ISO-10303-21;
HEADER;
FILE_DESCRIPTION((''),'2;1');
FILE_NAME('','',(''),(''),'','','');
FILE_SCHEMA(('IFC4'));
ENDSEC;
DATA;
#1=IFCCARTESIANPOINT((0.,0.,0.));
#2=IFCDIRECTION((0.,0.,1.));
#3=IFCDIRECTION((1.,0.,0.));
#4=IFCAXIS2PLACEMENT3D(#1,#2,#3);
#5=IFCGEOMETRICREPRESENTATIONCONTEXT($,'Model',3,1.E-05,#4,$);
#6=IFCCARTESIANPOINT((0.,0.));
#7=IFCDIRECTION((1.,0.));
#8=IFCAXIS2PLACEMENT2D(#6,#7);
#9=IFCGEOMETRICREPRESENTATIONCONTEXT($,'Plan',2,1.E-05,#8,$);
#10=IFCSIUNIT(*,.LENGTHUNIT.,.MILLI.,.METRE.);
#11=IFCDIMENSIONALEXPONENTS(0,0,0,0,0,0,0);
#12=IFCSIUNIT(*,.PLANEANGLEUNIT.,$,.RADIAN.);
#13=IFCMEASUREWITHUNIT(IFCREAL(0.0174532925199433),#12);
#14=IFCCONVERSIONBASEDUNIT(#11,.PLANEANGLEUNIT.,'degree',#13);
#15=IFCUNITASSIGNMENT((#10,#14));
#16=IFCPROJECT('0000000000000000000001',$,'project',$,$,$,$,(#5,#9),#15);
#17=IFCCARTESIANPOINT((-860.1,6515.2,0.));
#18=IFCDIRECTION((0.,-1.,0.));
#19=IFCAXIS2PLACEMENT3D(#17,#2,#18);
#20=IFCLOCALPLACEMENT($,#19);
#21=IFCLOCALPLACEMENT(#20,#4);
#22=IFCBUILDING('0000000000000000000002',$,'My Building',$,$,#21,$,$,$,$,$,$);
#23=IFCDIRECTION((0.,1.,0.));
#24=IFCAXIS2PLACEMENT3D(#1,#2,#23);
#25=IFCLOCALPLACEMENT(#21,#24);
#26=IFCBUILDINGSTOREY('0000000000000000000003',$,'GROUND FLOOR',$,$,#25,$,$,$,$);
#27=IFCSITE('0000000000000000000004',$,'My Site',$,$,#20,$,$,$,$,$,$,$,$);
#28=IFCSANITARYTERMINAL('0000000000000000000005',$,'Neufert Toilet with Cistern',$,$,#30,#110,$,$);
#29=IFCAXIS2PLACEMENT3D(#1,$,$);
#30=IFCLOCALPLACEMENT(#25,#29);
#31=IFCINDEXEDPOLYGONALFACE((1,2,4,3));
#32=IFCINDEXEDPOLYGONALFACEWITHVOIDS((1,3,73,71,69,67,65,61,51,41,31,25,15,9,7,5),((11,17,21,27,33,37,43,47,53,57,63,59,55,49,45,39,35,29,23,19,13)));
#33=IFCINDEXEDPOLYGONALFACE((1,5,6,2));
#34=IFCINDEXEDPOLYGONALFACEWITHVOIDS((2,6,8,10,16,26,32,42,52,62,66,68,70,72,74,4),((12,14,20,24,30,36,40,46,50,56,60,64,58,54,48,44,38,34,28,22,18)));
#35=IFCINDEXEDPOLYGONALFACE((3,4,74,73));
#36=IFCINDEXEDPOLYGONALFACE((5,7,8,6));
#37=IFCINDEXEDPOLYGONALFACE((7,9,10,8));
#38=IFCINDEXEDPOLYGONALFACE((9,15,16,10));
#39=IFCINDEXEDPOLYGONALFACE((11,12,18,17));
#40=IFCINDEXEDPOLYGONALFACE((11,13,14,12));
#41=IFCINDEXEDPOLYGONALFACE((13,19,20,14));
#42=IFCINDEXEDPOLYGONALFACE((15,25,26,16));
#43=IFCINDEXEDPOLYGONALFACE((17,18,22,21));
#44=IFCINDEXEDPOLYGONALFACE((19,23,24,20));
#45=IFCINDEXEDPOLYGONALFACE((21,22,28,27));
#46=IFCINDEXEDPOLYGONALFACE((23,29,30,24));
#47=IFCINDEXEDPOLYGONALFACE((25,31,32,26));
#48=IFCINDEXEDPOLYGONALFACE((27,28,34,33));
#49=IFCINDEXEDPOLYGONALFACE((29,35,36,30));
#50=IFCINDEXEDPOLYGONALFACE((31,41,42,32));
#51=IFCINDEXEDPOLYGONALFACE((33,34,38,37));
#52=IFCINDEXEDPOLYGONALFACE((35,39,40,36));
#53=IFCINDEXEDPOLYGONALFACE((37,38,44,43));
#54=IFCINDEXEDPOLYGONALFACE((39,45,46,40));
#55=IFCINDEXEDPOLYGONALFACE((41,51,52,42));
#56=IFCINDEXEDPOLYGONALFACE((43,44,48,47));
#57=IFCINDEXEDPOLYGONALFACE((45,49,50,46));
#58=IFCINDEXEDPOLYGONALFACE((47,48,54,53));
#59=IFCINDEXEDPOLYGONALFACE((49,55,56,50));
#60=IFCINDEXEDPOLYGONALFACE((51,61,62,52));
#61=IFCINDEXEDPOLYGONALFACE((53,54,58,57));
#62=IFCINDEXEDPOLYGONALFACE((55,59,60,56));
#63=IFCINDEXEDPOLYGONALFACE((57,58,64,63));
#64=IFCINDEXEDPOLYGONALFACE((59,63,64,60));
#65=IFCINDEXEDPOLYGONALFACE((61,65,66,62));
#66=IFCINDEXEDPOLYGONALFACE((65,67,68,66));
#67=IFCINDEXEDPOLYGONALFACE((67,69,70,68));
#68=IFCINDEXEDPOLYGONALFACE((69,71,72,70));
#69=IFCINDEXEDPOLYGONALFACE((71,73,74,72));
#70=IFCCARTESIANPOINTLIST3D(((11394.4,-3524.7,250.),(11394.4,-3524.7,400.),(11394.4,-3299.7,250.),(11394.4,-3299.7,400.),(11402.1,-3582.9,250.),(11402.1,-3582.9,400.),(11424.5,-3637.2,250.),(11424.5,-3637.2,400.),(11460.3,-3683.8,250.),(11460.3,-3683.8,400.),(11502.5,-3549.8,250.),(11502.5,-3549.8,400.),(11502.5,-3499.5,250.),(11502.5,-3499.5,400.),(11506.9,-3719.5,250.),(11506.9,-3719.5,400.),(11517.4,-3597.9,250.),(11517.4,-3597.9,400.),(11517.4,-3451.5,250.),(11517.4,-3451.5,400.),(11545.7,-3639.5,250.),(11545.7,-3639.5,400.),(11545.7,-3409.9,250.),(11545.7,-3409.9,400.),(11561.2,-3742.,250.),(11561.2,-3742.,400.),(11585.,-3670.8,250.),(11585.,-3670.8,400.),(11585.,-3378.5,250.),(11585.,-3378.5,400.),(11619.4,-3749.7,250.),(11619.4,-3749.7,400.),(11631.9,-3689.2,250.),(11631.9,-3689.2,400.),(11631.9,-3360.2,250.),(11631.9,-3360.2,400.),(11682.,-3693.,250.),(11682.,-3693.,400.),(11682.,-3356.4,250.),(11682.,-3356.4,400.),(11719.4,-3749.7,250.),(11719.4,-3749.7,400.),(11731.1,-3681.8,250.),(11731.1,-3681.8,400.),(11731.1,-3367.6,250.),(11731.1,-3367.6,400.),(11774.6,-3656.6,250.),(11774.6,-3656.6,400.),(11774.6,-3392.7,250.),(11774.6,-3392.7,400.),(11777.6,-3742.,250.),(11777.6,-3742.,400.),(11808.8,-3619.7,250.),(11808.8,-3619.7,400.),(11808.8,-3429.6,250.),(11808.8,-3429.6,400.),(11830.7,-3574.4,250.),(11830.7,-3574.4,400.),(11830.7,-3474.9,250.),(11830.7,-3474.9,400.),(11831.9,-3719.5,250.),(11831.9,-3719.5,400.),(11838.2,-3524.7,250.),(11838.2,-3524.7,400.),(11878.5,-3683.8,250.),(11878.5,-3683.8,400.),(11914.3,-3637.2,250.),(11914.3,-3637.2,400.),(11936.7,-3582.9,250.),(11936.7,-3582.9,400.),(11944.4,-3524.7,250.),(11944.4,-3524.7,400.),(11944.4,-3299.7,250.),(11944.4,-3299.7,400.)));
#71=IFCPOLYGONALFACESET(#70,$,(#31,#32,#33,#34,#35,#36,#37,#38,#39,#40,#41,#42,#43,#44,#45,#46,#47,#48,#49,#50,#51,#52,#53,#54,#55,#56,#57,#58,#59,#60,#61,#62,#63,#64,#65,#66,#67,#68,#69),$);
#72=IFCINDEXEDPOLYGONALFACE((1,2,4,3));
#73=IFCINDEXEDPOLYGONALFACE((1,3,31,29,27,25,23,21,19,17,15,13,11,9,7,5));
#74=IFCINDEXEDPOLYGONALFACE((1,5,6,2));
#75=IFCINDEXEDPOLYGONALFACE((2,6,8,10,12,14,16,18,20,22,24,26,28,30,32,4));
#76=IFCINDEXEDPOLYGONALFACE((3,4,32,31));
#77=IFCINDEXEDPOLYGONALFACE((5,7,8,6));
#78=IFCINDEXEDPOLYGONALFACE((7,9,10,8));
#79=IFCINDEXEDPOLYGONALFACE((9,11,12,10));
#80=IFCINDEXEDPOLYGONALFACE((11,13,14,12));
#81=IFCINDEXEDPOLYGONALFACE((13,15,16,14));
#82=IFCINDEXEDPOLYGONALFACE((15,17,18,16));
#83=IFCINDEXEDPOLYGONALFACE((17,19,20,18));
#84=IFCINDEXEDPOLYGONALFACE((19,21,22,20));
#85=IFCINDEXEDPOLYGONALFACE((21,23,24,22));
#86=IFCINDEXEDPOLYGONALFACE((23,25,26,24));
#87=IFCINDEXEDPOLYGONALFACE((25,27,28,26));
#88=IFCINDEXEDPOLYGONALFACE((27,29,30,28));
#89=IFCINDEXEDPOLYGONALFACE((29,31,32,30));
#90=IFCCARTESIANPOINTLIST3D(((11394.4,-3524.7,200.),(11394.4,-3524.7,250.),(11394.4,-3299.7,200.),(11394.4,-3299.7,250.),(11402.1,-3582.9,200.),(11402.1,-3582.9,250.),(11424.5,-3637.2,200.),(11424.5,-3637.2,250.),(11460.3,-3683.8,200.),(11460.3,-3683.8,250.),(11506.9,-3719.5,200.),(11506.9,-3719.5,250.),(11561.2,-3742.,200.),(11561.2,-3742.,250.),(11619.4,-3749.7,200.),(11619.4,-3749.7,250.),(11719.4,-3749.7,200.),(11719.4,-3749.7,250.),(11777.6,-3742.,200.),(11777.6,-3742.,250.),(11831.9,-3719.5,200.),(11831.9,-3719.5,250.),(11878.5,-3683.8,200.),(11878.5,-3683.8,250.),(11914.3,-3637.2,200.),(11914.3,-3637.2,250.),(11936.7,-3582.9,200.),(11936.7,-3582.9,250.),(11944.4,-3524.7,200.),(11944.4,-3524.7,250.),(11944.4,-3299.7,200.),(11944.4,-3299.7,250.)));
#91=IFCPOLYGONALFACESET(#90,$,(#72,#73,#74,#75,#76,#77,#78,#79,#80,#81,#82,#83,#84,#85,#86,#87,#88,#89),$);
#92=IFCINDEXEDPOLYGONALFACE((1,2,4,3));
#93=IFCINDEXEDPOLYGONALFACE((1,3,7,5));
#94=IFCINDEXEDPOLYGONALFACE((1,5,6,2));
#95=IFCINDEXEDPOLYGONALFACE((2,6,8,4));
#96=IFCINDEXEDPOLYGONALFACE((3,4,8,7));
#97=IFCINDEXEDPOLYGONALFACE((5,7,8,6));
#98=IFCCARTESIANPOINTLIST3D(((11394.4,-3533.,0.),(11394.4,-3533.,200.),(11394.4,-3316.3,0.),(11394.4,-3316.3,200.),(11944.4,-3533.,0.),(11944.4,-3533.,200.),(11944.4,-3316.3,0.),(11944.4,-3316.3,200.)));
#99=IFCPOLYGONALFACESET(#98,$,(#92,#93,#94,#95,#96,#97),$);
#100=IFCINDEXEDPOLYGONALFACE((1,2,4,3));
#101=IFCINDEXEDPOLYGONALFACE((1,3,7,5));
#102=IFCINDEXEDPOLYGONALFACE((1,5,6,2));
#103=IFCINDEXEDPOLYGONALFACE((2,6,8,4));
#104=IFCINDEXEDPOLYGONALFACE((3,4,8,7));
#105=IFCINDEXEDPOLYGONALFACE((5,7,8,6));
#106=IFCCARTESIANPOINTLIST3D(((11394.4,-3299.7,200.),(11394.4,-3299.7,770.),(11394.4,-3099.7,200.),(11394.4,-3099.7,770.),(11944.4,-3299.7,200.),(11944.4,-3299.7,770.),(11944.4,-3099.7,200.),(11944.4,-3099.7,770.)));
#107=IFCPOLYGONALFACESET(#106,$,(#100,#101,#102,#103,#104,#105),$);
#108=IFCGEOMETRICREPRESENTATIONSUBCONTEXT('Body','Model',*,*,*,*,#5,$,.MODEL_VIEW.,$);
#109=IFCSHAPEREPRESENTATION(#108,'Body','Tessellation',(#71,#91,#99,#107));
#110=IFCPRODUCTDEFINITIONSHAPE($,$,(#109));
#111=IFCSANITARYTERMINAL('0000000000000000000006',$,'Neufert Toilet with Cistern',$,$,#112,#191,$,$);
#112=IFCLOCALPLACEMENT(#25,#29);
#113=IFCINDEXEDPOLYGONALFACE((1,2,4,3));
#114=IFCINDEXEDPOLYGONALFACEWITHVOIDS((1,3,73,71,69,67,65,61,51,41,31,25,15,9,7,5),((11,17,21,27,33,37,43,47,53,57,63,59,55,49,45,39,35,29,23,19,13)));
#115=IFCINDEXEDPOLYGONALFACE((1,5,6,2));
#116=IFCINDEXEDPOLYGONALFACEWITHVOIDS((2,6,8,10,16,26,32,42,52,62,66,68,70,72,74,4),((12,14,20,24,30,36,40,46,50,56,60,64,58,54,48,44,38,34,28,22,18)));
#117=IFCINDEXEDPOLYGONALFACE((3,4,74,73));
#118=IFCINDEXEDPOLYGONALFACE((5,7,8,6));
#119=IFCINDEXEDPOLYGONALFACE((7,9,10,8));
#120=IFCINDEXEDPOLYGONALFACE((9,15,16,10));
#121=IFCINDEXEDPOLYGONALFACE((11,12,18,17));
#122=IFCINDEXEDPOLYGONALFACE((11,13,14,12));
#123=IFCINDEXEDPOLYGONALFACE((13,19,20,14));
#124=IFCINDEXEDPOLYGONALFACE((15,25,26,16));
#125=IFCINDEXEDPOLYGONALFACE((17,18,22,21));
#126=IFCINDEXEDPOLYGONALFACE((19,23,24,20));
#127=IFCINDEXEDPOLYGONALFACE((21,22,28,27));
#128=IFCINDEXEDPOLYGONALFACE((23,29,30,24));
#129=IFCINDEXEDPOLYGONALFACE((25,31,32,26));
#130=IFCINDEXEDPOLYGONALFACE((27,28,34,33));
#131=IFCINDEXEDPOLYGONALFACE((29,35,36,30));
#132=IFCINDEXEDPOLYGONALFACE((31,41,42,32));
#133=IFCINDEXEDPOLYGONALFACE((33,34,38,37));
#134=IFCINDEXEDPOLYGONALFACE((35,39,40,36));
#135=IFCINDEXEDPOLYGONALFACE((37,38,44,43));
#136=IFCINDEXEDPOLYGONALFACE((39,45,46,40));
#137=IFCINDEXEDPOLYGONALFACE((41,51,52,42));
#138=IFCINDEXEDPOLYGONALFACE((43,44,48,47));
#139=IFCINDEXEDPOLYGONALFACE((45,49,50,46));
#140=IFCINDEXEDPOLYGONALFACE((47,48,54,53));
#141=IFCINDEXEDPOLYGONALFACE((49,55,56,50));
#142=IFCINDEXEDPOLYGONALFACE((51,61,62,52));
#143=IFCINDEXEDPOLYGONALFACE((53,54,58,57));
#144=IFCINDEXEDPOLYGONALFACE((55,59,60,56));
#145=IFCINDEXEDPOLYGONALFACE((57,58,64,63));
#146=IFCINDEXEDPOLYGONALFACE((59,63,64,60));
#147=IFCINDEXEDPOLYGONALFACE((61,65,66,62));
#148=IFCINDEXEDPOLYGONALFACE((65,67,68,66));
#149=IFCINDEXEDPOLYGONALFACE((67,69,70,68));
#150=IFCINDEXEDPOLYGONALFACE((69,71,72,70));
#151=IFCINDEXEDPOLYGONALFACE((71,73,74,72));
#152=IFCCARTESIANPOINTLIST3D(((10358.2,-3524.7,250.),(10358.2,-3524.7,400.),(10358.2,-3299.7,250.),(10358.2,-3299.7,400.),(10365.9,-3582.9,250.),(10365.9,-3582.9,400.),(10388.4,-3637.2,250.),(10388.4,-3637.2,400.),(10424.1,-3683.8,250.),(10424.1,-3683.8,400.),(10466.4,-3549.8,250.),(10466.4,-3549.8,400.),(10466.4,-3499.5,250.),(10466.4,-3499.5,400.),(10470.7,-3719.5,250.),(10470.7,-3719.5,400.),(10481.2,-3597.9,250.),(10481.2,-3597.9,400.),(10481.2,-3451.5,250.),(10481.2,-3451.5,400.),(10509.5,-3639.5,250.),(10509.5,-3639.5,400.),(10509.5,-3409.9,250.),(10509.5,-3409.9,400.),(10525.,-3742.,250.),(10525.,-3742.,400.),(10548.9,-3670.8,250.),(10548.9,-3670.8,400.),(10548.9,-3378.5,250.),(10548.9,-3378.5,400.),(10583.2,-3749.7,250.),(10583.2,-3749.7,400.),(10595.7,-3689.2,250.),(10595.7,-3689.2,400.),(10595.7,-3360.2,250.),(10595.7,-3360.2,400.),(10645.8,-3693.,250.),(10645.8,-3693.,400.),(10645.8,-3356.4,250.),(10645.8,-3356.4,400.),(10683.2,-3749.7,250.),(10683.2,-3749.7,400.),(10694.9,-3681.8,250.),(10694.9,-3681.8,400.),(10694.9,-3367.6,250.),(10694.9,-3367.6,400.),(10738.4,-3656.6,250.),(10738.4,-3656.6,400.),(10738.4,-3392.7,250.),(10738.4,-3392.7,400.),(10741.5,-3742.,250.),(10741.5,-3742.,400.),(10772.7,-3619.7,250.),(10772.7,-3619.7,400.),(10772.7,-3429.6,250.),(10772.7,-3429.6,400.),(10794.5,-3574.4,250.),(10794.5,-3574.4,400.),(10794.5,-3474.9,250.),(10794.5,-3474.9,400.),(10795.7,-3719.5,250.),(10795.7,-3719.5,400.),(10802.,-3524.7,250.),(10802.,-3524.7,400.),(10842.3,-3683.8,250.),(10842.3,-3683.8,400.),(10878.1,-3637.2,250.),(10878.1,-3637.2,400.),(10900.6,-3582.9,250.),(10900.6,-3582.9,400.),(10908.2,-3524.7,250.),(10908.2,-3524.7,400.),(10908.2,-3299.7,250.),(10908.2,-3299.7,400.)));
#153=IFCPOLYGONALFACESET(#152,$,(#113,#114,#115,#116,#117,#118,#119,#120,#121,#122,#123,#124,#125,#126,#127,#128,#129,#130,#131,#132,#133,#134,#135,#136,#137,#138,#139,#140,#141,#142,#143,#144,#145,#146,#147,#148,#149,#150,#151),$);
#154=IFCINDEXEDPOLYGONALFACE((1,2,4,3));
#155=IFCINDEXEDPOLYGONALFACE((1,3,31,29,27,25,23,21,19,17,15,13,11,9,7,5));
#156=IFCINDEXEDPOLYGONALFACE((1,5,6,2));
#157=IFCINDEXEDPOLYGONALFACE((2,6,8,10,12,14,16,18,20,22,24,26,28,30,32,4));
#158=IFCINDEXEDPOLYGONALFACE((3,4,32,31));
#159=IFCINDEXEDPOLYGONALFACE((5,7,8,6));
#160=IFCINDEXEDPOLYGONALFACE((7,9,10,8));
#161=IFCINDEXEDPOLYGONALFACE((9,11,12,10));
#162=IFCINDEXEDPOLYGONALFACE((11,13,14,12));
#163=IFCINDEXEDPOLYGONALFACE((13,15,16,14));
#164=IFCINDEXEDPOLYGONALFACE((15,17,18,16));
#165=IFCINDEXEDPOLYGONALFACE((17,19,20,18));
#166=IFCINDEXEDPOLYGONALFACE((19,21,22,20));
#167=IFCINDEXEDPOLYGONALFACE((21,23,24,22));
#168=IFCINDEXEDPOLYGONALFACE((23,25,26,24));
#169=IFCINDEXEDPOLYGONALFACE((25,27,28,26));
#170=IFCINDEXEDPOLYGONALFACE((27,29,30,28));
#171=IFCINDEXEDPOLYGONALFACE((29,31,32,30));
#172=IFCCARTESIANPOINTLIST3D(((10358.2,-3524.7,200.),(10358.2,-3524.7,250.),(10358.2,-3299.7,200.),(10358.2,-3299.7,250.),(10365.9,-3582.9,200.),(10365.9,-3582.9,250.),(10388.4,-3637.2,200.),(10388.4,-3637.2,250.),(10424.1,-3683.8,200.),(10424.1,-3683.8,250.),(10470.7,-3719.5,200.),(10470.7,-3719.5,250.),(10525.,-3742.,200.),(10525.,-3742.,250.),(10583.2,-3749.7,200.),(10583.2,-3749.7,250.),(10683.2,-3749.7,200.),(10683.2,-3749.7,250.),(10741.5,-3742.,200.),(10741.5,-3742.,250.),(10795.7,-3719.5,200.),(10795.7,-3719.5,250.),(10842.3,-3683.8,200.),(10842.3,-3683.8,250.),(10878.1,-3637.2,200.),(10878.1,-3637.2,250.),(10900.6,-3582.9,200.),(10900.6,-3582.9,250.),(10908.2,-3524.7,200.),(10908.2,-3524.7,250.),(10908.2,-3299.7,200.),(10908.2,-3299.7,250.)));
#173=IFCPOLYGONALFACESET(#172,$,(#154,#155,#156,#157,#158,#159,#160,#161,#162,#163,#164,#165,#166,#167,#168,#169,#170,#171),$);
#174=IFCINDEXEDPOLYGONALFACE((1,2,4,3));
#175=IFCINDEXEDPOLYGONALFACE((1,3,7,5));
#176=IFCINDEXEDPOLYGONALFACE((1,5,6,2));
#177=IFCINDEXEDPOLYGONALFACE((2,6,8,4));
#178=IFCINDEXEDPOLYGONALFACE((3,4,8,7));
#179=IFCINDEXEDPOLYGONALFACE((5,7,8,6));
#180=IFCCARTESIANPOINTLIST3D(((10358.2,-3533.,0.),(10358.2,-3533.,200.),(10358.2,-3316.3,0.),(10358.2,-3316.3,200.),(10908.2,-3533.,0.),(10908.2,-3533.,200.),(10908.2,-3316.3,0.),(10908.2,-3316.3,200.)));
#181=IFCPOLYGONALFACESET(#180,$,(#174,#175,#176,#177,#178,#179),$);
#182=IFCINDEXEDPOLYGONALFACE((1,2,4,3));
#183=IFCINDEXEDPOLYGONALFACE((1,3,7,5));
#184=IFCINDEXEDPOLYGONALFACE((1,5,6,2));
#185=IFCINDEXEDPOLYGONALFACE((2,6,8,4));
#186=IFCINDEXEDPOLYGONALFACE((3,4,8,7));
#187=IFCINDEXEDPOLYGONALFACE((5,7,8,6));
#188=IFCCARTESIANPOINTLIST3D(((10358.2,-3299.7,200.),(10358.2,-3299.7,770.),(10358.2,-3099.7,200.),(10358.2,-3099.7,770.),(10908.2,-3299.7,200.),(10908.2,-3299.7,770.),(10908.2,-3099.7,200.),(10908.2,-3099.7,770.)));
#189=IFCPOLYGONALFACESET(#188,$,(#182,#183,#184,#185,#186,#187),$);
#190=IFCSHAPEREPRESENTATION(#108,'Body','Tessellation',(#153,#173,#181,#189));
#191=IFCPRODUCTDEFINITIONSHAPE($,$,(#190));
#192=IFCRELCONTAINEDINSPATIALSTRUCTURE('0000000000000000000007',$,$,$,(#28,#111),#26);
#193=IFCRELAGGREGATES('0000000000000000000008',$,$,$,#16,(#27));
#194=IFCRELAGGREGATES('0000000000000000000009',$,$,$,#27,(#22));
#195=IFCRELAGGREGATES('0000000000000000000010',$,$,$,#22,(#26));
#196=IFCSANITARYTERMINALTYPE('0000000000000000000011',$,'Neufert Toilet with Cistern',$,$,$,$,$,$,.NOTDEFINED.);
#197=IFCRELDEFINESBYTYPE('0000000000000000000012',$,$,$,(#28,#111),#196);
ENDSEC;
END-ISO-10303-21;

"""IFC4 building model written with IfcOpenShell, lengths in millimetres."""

from ifc_helpers import new_model, entity, si_unit, converted_unit, frame, frame_2d, origin_with_axes, origin_2d_with_axis, place, context, subcontext, project, spatial, line, arc, indexed_curve, circle_curve, outline, extrude, shape, source, transform, mapped, type_object, type_shapes, element, save


model = new_model("IFC4")

# Units and contexts
model_context = context("Model", 3, precision=1e-05, world=origin_with_axes())
plan_context = context("Plan", 2, precision=1e-05, world=origin_2d_with_axis())
body_context_1 = subcontext(model_context, "Body", "Model", "MODEL_VIEW")
body_context_2 = subcontext(plan_context, "Body", "Plan", "PLAN_VIEW")
ifc_project = project(units=[si_unit("LENGTHUNIT", "METRE", prefix="MILLI"), converted_unit("PLANEANGLEUNIT", "degree", entity("IfcReal", 0.0174532925199433), si_unit("PLANEANGLEUNIT", "RADIAN"), dimensions=[0, 0, 0, 0, 0, 0, 0])], contexts=[model_context, plan_context])

# Site, building, storey
site_placement = place(None, frame((-860.1, 6515.2, 0.0), z_axis=(0.0, 0.0, 1.0), x_axis=(0.0, -1.0, 0.0)))
site = spatial("IfcSite", under=ifc_project, at=site_placement, Name="My Site")
building_placement = place(site_placement, frame((0.0, 0.0, 0.0), z_axis=(0.0, 0.0, 1.0), x_axis=(1.0, 0.0, 0.0)))
building = spatial("IfcBuilding", under=site, at=building_placement, Name="My Building")
storey_placement = place(building_placement, frame((0.0, 0.0, 0.0), z_axis=(0.0, 0.0, 1.0), x_axis=(0.0, 1.0, 0.0)))
storey = spatial("IfcBuildingStorey", under=building, at=storey_placement, Name="GROUND FLOOR")

# Sanitary terminals
sanitary_terminal_type_1 = type_object("IfcSanitaryTerminalType", Name="Neufert Toilet with Cistern", PredefinedType="NOTDEFINED")
shared_shape_1 = source(origin_with_axes(), body_context_1, "Body", "SweptSolid", [
    extrude(outline(indexed_curve([(-275.0, -200.0), (275.0, -200.0), (275.0, -425.0), (209.1, -584.1), (50.0, -650.0), (-50.0, -650.0), (-209.1, -584.1), (-275.0, -425.0)], segments=[line(1, 2), line(2, 3), arc(3, 4, 5), line(5, 6), arc(6, 7, 8), line(8, 1)]), holes=[circle_curve(frame_2d((0.0, -425.0)), 168.8)]), frame((0.0, 0.0, 250.0), z_axis=(0.0, 0.0, 1.0), x_axis=(1.0, 0.0, 0.0)), (0.0, 0.0, 1.0), 150.0),
    extrude(outline(indexed_curve([(-275.0, -200.0), (275.0, -200.0), (275.0, -425.0), (209.1, -584.1), (50.0, -650.0), (-50.0, -650.0), (-209.1, -584.1), (-275.0, -425.0)], segments=[line(1, 2), line(2, 3), arc(3, 4, 5), line(5, 6), arc(6, 7, 8), line(8, 1)])), frame((0.0, 0.0, 200.0), z_axis=(0.0, 0.0, 1.0), x_axis=(1.0, 0.0, 0.0)), (0.0, 0.0, 1.0), 50.0),
    extrude(outline(indexed_curve([(-275.0, -216.7), (275.0, -216.7), (275.0, -433.3), (-275.0, -433.3)], segments=[line(1, 2), line(2, 3), line(3, 4), line(4, 1)])), origin_with_axes(), (0.0, 0.0, 1.0), 200.0),
    extrude(outline(indexed_curve([(-275.0, 0.0), (275.0, 0.0), (275.0, -200.0), (-275.0, -200.0)], segments=[line(1, 2), line(2, 3), line(3, 4), line(4, 1)])), frame((0.0, 0.0, 200.0), z_axis=(0.0, 0.0, 1.0), x_axis=(1.0, 0.0, 0.0)), (0.0, 0.0, 1.0), 570.0),
])
shared_shape_2 = source(origin_with_axes(), body_context_2, "Body", "Curve2D", [
    entity("IfcIndexedPolyCurve", entity("IfcCartesianPointList2D", [[-275.0, 0.0], [275.0, 0.0], [275.0, -200.0], [-275.0, -200.0]]), [entity("IfcLineIndex", [1, 2]), entity("IfcLineIndex", [2, 3]), entity("IfcLineIndex", [3, 4]), entity("IfcLineIndex", [4, 1])]),
    entity("IfcIndexedPolyCurve", entity("IfcCartesianPointList2D", [[165.0, -200.0], [192.5, -335.0]]), [entity("IfcLineIndex", [1, 2])]),
    entity("IfcTrimmedCurve", entity("IfcEllipse", entity("IfcAxis2Placement2D", entity("IfcCartesianPoint", [0.0, -335.0]), entity("IfcDirection", [1.0, 0.0])), 192.5, 315.0), [entity("IfcCartesianPoint", [-192.5, -335.0])], [entity("IfcCartesianPoint", [192.5, -335.0])], True, "CARTESIAN"),
    entity("IfcIndexedPolyCurve", entity("IfcCartesianPointList2D", [[-165.0, -200.0], [-192.5, -335.0]]), [entity("IfcLineIndex", [1, 2])]),
    entity("IfcEllipse", entity("IfcAxis2Placement2D", entity("IfcCartesianPoint", [0.0, -452.0]), entity("IfcDirection", [1.0, 0.0])), 131.2, 157.5),
    entity("IfcIndexedPolyCurve", entity("IfcCartesianPointList2D", [[-34.4, -452.0], [-34.4, -429.5], [34.4, -429.5], [34.4, -452.0]]), [entity("IfcLineIndex", [1, 2]), entity("IfcLineIndex", [2, 3]), entity("IfcLineIndex", [3, 4])]),
    entity("IfcTrimmedCurve", entity("IfcEllipse", entity("IfcAxis2Placement2D", entity("IfcCartesianPoint", [0.0, -452.0]), entity("IfcDirection", [1.0, 0.0])), 34.4, 22.5), [entity("IfcCartesianPoint", [-34.4, -452.0])], [entity("IfcCartesianPoint", [34.4, -452.0])], True, "CARTESIAN"),
])
type_shapes(sanitary_terminal_type_1, [shared_shape_1, shared_shape_2])
for number, where, z_axis, x_axis, name in (
    (1, (11669.4, -3099.7, 0.0), (0.0, 0.0, 1.0), (1.0, 0.0, 0.0), "Neufert Toilet with Cistern"),
    (2, (10633.2, -3099.7, 0.0), (0.0, 0.0, 1.0), (1.0, 0.0, 0.0), "Neufert Toilet with Cistern"),
):
    element("IfcSanitaryTerminal", number, at=place(storey_placement, frame(where, z_axis=z_axis, x_axis=x_axis)), inside=storey, type_object=sanitary_terminal_type_1, Name=name, shapes=[
        shape(body_context_1, "Body", "MappedRepresentation", [mapped(shared_shape_1, transform((0.0, 0.0, 0.0), x_axis=(1.0, 0.0, 0.0), y_axis=(0.0, 1.0, 0.0), z_axis=(0.0, 0.0, 1.0), scale=1.0))]),
        shape(body_context_2, "Body", "MappedRepresentation", [mapped(shared_shape_2, transform((0.0, 0.0, 0.0), x_axis=(1.0, 0.0, 0.0), y_axis=(0.0, 1.0, 0.0), z_axis=(0.0, 0.0, 1.0), scale=1.0))]),
    ])

save(model, "model.ifc")
